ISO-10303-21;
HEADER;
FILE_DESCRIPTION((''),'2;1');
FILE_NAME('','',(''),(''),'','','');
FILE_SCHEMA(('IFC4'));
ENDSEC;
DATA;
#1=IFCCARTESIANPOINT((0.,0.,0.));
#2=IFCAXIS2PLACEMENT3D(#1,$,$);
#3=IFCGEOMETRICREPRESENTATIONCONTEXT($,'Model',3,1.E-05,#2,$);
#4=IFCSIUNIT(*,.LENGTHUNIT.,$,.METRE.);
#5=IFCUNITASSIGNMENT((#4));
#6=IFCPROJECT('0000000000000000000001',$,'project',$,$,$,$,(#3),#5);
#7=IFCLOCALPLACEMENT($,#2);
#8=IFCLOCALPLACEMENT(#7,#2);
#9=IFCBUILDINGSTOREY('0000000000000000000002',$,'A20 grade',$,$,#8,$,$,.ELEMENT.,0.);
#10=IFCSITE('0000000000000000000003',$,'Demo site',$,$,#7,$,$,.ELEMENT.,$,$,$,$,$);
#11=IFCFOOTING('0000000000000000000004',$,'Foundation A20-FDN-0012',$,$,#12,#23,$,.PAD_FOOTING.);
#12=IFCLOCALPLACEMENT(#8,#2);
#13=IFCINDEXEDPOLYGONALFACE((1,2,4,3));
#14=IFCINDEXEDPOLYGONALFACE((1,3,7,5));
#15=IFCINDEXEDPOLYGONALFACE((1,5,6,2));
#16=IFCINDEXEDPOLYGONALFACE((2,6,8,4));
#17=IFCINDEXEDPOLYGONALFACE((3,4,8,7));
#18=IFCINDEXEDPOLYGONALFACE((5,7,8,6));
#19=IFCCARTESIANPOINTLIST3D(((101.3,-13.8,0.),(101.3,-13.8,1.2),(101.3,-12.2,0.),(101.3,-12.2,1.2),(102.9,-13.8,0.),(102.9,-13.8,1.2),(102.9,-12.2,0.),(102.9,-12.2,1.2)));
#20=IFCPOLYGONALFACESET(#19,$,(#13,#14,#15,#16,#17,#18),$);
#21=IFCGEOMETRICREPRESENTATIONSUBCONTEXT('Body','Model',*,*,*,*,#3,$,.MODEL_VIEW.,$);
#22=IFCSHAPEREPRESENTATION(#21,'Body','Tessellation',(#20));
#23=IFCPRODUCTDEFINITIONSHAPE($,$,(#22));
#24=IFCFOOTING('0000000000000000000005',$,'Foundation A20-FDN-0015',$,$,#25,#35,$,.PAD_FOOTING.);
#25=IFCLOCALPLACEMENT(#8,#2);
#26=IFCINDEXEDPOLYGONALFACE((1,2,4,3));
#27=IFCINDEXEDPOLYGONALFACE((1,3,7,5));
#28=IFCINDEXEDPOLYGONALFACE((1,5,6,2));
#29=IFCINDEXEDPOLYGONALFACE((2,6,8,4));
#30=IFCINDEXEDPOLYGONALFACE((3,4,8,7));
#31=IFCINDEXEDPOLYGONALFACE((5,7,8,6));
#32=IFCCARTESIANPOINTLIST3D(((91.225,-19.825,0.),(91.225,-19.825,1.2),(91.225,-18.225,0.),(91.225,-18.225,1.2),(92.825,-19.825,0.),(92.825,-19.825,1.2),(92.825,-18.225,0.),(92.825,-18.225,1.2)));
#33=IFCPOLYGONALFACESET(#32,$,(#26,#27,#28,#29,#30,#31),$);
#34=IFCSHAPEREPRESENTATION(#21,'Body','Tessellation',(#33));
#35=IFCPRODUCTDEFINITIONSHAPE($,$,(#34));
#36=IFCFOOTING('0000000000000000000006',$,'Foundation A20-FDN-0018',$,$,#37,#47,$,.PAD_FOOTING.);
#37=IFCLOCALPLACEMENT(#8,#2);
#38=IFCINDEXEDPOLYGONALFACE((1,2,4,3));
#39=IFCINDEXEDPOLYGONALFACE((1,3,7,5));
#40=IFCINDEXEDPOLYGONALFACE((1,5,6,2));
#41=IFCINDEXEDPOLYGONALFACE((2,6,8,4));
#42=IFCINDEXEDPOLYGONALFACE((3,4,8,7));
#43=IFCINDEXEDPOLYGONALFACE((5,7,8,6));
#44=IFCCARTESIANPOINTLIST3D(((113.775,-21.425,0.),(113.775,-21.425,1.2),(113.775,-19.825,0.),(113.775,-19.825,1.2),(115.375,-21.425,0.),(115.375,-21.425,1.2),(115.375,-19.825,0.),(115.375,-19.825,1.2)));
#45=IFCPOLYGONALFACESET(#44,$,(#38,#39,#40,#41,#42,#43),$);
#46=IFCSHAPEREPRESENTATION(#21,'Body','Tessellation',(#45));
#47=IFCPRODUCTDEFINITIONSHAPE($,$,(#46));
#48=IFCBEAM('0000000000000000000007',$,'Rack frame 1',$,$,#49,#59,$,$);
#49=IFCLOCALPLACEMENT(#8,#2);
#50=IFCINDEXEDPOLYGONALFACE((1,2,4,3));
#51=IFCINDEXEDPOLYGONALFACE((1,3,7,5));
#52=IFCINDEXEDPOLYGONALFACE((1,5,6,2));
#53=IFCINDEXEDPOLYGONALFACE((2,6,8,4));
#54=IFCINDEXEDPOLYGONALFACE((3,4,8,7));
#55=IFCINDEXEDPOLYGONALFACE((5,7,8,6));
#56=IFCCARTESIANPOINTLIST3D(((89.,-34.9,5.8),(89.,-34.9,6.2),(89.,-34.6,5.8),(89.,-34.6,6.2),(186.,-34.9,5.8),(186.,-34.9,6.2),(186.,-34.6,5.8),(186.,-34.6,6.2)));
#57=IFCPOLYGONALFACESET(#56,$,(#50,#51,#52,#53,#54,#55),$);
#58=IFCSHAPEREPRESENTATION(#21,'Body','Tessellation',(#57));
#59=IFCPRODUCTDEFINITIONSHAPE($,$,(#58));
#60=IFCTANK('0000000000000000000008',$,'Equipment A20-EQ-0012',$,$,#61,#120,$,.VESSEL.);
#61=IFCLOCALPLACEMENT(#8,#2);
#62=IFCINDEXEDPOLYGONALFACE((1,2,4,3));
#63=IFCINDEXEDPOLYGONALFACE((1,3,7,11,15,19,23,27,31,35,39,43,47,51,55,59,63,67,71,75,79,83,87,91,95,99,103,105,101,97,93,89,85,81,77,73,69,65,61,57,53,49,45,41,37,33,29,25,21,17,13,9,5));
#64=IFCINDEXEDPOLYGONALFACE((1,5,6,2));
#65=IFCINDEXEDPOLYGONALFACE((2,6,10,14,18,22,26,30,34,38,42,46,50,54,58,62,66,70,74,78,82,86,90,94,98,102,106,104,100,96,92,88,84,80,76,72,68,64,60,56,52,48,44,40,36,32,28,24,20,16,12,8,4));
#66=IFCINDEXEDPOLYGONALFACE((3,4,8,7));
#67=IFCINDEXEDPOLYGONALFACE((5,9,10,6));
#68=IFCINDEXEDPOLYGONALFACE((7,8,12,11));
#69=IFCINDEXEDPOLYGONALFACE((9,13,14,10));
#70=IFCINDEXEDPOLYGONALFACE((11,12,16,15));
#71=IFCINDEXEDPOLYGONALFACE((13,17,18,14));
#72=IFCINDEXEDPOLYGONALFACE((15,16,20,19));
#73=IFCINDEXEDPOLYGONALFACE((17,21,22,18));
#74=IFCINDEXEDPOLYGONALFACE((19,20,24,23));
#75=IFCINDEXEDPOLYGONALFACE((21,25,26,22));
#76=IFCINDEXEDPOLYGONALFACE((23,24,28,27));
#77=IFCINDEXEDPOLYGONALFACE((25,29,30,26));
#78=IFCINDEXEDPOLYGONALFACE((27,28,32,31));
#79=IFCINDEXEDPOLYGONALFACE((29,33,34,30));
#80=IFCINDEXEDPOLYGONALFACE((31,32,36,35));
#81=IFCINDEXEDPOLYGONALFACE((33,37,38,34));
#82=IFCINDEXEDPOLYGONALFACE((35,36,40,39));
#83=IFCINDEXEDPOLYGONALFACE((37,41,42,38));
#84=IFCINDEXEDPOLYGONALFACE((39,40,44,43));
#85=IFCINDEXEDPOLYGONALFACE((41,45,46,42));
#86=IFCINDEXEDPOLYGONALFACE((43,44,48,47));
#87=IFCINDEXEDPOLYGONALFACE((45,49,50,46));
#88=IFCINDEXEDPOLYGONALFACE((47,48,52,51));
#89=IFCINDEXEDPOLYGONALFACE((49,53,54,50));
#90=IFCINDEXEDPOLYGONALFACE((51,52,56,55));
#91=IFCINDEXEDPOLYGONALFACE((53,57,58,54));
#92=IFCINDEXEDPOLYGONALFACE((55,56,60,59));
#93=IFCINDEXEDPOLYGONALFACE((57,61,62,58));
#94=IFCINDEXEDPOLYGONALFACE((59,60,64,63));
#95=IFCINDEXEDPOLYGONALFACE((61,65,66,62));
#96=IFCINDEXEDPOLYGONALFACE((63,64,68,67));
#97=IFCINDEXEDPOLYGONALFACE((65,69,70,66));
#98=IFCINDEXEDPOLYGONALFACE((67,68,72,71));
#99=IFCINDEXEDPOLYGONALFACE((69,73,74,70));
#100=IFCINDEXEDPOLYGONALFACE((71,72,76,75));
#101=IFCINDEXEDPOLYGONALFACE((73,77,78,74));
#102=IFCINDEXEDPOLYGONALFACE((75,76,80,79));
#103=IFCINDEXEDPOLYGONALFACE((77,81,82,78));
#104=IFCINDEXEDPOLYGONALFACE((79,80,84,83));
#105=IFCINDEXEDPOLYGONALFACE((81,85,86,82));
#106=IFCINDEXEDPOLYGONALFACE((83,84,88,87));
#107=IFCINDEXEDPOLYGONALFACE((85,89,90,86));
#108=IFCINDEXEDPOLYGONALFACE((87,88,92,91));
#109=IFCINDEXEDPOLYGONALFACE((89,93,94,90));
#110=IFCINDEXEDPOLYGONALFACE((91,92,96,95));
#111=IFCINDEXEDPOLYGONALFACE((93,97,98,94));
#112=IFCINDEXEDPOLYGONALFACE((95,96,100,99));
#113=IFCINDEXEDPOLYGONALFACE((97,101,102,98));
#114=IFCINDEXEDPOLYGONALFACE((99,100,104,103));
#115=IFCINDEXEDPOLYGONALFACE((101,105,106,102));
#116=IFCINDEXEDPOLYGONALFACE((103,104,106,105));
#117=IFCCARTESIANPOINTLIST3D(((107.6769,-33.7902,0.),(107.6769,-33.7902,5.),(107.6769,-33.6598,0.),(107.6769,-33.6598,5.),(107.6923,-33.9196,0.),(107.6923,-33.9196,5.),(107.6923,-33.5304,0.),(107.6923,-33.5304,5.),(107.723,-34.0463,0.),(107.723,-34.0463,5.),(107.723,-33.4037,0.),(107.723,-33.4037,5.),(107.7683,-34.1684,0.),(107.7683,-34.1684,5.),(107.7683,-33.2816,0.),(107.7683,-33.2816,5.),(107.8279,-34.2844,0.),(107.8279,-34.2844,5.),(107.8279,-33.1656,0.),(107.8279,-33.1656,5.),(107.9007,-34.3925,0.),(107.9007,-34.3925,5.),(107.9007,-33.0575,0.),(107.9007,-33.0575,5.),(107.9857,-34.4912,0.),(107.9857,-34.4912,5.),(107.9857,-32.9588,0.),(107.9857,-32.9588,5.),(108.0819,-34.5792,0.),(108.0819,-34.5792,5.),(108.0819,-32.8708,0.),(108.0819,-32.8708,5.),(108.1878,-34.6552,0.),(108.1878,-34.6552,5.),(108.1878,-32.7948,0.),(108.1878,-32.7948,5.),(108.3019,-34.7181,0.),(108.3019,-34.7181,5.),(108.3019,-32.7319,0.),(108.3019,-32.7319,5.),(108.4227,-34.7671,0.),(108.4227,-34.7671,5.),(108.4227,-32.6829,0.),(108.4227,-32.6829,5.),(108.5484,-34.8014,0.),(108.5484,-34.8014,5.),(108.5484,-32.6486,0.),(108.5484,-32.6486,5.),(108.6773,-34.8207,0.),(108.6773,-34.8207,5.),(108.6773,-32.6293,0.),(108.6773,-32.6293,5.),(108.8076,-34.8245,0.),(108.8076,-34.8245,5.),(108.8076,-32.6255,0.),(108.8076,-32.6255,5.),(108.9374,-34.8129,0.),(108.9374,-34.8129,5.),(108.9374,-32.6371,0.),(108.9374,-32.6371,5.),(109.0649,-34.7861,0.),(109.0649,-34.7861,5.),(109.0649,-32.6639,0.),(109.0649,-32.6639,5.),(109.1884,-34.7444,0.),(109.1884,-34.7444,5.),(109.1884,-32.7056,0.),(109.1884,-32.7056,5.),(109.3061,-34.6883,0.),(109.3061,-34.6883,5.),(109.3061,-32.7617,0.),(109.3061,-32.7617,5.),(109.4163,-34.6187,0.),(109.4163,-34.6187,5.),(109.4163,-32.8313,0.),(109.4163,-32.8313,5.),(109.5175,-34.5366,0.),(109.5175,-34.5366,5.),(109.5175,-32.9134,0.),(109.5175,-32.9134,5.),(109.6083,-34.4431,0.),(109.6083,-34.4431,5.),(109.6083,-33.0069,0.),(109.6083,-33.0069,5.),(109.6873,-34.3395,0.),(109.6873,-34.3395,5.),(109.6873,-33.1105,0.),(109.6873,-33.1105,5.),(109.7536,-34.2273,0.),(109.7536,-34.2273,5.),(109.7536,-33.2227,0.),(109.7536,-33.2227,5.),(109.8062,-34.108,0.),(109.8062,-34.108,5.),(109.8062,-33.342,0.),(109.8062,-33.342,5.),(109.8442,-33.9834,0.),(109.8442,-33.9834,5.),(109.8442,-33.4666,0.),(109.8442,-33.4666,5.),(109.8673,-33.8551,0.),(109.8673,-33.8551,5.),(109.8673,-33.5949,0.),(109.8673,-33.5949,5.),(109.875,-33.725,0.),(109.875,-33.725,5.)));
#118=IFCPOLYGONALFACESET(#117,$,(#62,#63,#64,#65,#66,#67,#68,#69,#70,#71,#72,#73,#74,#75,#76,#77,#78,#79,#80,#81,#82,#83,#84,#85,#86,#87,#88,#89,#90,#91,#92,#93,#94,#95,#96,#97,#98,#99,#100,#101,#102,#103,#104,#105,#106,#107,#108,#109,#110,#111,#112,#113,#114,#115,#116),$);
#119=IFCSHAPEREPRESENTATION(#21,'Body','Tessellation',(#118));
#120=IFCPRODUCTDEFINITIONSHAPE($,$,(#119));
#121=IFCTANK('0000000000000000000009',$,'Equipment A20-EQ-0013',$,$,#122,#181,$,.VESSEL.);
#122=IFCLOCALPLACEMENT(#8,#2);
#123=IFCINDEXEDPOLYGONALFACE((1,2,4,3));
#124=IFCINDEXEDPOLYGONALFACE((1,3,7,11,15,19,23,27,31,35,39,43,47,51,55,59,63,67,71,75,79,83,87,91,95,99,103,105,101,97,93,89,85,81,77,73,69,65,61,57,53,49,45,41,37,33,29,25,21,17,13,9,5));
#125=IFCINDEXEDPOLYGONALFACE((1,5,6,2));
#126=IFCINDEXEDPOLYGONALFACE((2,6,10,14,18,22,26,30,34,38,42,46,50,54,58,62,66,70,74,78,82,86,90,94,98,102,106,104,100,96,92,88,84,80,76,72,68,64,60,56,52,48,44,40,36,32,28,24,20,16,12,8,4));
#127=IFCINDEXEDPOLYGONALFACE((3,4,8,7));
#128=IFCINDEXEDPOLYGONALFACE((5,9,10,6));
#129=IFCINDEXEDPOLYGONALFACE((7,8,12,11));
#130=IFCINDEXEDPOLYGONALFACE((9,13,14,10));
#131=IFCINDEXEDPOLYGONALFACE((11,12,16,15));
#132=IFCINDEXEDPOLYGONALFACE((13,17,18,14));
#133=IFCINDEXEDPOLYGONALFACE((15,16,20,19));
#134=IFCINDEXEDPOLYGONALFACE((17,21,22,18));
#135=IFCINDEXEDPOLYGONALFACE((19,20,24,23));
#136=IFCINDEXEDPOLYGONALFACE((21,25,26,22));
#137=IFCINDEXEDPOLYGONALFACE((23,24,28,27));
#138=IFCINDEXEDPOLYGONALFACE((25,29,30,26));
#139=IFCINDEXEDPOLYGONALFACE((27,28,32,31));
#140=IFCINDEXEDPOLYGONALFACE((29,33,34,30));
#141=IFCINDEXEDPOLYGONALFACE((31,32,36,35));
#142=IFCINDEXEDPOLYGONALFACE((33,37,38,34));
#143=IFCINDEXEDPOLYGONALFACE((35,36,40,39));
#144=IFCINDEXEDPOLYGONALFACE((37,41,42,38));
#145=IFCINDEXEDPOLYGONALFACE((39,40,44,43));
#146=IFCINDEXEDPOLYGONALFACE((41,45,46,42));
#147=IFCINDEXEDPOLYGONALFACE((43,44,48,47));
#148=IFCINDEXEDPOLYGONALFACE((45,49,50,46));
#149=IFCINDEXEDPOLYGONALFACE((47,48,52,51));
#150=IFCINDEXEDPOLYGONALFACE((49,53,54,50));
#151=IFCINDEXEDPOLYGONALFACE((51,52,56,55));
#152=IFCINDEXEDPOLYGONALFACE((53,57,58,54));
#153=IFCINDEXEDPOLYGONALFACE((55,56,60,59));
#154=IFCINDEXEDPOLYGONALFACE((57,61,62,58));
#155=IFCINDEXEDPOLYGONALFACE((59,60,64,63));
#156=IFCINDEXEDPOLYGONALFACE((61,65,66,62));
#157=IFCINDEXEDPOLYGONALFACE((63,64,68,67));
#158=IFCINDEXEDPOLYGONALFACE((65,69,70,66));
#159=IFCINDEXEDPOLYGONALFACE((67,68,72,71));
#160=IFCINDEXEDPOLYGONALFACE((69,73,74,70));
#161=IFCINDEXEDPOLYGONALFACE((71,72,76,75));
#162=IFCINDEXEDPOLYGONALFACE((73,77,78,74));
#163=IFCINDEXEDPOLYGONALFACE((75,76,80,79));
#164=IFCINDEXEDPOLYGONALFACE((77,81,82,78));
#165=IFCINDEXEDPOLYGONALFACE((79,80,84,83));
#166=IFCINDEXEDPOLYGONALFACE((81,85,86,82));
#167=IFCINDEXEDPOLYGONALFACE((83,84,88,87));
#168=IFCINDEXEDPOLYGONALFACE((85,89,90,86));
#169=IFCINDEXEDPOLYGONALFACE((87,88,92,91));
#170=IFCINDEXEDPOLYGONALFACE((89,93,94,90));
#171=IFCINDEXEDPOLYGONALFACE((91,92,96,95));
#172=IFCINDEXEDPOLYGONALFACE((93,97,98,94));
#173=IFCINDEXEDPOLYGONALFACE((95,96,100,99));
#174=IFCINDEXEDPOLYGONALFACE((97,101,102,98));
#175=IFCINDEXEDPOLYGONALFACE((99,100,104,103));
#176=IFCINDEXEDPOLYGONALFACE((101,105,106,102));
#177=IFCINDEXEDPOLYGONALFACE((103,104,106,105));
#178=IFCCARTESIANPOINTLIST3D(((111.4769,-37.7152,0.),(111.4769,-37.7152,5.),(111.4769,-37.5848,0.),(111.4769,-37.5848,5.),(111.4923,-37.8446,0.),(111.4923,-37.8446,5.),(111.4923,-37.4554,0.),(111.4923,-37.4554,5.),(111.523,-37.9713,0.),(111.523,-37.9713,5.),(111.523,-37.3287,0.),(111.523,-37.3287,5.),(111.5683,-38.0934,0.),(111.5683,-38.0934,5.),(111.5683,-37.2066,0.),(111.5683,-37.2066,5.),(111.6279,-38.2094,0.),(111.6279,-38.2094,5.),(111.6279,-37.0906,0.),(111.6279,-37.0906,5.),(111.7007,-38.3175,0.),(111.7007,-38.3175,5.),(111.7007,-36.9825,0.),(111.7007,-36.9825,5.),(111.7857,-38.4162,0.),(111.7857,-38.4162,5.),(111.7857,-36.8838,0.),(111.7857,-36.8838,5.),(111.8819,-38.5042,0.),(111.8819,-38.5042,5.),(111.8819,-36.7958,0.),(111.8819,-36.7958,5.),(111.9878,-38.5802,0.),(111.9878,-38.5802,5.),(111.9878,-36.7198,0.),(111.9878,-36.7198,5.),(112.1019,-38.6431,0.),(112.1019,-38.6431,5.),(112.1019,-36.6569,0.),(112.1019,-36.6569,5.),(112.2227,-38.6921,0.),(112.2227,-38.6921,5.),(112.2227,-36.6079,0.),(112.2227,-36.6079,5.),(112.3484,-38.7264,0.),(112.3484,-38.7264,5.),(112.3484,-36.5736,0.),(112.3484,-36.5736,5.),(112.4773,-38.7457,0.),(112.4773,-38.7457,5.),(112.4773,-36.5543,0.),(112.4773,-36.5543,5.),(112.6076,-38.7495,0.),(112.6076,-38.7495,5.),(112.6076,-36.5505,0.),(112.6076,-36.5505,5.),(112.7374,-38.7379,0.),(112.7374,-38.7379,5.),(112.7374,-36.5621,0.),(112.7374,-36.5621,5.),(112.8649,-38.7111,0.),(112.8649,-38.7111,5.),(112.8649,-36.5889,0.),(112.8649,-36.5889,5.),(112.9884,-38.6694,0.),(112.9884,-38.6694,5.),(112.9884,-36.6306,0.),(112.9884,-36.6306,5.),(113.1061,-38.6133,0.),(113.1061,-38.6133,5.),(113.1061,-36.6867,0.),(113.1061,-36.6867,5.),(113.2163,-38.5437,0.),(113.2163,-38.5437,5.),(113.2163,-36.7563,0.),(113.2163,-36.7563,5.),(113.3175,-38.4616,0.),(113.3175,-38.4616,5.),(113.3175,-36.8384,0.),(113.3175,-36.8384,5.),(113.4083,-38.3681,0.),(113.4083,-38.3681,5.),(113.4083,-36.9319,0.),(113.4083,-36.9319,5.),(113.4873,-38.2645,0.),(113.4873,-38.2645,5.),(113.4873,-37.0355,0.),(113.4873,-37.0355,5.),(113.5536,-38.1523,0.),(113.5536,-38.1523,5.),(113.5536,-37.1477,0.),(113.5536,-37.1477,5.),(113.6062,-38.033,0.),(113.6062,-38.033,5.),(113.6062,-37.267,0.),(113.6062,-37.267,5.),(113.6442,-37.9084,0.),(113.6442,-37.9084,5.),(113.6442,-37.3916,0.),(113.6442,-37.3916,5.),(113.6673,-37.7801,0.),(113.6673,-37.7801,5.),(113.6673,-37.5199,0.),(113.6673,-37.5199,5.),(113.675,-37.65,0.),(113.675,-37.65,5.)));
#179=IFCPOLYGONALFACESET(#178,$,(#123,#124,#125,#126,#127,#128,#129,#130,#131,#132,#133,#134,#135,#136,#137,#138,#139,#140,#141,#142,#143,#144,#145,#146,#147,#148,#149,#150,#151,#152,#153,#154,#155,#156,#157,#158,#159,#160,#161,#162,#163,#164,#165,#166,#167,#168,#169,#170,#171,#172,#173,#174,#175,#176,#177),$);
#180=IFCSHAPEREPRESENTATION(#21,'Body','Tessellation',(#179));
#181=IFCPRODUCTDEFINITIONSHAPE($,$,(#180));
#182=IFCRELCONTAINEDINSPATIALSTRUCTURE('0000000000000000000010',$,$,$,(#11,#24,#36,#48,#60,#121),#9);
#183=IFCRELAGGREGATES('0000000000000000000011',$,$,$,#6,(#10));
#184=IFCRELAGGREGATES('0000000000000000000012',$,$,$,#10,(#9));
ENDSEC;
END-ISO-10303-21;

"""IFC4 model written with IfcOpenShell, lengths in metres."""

from ifc_helpers import new_model, si_unit, frame, origin, place, context, subcontext, project, spatial, rectangle, circle, extrude, element, save


model = new_model("IFC4")

# Units and contexts
model_context = context("Model", 3, precision=1e-05, world=origin())
body_context = subcontext(model_context, "Body", "Model", "MODEL_VIEW")
ifc_project = project(units=[si_unit("LENGTHUNIT", "METRE")], contexts=[model_context])

# Site, storey
site_placement = place(None, origin())
site = spatial("IfcSite", under=ifc_project, at=site_placement, Name="Demo site", CompositionType="ELEMENT")
storey_placement = place(site_placement, origin())
storey = spatial("IfcBuildingStorey", under=site, at=storey_placement, Name="A20 grade", CompositionType="ELEMENT", Elevation=0.0)

# Footings
for number, where, name in (
    (1, (102.1, -13.0, 0.0), "Foundation A20-FDN-0012"),
    (2, (92.025, -19.025, 0.0), "Foundation A20-FDN-0015"),
    (3, (114.575, -20.625, 0.0), "Foundation A20-FDN-0018"),
):
    element("IfcFooting", number, at=place(storey_placement, frame(where)), inside=storey, Name=name, PredefinedType="PAD_FOOTING", context=body_context, shape_type="SweptSolid", body=[
        extrude(rectangle(XDim=1.6, YDim=1.6), origin(), (0.0, 0.0, 1.0), 1.2),
    ])

# Beam
beam_placement = place(storey_placement, frame((89.0, -34.75, 6.0)))
element("IfcBeam", 4, at=beam_placement, inside=storey, Name="Rack frame 1", context=body_context, shape_type="SweptSolid", body=[
    extrude(rectangle(XDim=0.3, YDim=0.4), frame((0.0, 0.0, 0.0), z_axis=(1.0, 0.0, 0.0), x_axis=(0.0, 1.0, 0.0)), (0.0, 0.0, 1.0), 97.0),
])

# Tanks
for number, where, name in (
    (5, (108.775, -33.725, 0.0), "Equipment A20-EQ-0012"),
    (6, (112.575, -37.65, 0.0), "Equipment A20-EQ-0013"),
):
    element("IfcTank", number, at=place(storey_placement, frame(where)), inside=storey, Name=name, PredefinedType="VESSEL", context=body_context, shape_type="SweptSolid", body=[
        extrude(circle(Radius=1.1), origin(), (0.0, 0.0, 1.0), 5.0),
    ])

save(model, "model.ifc")
